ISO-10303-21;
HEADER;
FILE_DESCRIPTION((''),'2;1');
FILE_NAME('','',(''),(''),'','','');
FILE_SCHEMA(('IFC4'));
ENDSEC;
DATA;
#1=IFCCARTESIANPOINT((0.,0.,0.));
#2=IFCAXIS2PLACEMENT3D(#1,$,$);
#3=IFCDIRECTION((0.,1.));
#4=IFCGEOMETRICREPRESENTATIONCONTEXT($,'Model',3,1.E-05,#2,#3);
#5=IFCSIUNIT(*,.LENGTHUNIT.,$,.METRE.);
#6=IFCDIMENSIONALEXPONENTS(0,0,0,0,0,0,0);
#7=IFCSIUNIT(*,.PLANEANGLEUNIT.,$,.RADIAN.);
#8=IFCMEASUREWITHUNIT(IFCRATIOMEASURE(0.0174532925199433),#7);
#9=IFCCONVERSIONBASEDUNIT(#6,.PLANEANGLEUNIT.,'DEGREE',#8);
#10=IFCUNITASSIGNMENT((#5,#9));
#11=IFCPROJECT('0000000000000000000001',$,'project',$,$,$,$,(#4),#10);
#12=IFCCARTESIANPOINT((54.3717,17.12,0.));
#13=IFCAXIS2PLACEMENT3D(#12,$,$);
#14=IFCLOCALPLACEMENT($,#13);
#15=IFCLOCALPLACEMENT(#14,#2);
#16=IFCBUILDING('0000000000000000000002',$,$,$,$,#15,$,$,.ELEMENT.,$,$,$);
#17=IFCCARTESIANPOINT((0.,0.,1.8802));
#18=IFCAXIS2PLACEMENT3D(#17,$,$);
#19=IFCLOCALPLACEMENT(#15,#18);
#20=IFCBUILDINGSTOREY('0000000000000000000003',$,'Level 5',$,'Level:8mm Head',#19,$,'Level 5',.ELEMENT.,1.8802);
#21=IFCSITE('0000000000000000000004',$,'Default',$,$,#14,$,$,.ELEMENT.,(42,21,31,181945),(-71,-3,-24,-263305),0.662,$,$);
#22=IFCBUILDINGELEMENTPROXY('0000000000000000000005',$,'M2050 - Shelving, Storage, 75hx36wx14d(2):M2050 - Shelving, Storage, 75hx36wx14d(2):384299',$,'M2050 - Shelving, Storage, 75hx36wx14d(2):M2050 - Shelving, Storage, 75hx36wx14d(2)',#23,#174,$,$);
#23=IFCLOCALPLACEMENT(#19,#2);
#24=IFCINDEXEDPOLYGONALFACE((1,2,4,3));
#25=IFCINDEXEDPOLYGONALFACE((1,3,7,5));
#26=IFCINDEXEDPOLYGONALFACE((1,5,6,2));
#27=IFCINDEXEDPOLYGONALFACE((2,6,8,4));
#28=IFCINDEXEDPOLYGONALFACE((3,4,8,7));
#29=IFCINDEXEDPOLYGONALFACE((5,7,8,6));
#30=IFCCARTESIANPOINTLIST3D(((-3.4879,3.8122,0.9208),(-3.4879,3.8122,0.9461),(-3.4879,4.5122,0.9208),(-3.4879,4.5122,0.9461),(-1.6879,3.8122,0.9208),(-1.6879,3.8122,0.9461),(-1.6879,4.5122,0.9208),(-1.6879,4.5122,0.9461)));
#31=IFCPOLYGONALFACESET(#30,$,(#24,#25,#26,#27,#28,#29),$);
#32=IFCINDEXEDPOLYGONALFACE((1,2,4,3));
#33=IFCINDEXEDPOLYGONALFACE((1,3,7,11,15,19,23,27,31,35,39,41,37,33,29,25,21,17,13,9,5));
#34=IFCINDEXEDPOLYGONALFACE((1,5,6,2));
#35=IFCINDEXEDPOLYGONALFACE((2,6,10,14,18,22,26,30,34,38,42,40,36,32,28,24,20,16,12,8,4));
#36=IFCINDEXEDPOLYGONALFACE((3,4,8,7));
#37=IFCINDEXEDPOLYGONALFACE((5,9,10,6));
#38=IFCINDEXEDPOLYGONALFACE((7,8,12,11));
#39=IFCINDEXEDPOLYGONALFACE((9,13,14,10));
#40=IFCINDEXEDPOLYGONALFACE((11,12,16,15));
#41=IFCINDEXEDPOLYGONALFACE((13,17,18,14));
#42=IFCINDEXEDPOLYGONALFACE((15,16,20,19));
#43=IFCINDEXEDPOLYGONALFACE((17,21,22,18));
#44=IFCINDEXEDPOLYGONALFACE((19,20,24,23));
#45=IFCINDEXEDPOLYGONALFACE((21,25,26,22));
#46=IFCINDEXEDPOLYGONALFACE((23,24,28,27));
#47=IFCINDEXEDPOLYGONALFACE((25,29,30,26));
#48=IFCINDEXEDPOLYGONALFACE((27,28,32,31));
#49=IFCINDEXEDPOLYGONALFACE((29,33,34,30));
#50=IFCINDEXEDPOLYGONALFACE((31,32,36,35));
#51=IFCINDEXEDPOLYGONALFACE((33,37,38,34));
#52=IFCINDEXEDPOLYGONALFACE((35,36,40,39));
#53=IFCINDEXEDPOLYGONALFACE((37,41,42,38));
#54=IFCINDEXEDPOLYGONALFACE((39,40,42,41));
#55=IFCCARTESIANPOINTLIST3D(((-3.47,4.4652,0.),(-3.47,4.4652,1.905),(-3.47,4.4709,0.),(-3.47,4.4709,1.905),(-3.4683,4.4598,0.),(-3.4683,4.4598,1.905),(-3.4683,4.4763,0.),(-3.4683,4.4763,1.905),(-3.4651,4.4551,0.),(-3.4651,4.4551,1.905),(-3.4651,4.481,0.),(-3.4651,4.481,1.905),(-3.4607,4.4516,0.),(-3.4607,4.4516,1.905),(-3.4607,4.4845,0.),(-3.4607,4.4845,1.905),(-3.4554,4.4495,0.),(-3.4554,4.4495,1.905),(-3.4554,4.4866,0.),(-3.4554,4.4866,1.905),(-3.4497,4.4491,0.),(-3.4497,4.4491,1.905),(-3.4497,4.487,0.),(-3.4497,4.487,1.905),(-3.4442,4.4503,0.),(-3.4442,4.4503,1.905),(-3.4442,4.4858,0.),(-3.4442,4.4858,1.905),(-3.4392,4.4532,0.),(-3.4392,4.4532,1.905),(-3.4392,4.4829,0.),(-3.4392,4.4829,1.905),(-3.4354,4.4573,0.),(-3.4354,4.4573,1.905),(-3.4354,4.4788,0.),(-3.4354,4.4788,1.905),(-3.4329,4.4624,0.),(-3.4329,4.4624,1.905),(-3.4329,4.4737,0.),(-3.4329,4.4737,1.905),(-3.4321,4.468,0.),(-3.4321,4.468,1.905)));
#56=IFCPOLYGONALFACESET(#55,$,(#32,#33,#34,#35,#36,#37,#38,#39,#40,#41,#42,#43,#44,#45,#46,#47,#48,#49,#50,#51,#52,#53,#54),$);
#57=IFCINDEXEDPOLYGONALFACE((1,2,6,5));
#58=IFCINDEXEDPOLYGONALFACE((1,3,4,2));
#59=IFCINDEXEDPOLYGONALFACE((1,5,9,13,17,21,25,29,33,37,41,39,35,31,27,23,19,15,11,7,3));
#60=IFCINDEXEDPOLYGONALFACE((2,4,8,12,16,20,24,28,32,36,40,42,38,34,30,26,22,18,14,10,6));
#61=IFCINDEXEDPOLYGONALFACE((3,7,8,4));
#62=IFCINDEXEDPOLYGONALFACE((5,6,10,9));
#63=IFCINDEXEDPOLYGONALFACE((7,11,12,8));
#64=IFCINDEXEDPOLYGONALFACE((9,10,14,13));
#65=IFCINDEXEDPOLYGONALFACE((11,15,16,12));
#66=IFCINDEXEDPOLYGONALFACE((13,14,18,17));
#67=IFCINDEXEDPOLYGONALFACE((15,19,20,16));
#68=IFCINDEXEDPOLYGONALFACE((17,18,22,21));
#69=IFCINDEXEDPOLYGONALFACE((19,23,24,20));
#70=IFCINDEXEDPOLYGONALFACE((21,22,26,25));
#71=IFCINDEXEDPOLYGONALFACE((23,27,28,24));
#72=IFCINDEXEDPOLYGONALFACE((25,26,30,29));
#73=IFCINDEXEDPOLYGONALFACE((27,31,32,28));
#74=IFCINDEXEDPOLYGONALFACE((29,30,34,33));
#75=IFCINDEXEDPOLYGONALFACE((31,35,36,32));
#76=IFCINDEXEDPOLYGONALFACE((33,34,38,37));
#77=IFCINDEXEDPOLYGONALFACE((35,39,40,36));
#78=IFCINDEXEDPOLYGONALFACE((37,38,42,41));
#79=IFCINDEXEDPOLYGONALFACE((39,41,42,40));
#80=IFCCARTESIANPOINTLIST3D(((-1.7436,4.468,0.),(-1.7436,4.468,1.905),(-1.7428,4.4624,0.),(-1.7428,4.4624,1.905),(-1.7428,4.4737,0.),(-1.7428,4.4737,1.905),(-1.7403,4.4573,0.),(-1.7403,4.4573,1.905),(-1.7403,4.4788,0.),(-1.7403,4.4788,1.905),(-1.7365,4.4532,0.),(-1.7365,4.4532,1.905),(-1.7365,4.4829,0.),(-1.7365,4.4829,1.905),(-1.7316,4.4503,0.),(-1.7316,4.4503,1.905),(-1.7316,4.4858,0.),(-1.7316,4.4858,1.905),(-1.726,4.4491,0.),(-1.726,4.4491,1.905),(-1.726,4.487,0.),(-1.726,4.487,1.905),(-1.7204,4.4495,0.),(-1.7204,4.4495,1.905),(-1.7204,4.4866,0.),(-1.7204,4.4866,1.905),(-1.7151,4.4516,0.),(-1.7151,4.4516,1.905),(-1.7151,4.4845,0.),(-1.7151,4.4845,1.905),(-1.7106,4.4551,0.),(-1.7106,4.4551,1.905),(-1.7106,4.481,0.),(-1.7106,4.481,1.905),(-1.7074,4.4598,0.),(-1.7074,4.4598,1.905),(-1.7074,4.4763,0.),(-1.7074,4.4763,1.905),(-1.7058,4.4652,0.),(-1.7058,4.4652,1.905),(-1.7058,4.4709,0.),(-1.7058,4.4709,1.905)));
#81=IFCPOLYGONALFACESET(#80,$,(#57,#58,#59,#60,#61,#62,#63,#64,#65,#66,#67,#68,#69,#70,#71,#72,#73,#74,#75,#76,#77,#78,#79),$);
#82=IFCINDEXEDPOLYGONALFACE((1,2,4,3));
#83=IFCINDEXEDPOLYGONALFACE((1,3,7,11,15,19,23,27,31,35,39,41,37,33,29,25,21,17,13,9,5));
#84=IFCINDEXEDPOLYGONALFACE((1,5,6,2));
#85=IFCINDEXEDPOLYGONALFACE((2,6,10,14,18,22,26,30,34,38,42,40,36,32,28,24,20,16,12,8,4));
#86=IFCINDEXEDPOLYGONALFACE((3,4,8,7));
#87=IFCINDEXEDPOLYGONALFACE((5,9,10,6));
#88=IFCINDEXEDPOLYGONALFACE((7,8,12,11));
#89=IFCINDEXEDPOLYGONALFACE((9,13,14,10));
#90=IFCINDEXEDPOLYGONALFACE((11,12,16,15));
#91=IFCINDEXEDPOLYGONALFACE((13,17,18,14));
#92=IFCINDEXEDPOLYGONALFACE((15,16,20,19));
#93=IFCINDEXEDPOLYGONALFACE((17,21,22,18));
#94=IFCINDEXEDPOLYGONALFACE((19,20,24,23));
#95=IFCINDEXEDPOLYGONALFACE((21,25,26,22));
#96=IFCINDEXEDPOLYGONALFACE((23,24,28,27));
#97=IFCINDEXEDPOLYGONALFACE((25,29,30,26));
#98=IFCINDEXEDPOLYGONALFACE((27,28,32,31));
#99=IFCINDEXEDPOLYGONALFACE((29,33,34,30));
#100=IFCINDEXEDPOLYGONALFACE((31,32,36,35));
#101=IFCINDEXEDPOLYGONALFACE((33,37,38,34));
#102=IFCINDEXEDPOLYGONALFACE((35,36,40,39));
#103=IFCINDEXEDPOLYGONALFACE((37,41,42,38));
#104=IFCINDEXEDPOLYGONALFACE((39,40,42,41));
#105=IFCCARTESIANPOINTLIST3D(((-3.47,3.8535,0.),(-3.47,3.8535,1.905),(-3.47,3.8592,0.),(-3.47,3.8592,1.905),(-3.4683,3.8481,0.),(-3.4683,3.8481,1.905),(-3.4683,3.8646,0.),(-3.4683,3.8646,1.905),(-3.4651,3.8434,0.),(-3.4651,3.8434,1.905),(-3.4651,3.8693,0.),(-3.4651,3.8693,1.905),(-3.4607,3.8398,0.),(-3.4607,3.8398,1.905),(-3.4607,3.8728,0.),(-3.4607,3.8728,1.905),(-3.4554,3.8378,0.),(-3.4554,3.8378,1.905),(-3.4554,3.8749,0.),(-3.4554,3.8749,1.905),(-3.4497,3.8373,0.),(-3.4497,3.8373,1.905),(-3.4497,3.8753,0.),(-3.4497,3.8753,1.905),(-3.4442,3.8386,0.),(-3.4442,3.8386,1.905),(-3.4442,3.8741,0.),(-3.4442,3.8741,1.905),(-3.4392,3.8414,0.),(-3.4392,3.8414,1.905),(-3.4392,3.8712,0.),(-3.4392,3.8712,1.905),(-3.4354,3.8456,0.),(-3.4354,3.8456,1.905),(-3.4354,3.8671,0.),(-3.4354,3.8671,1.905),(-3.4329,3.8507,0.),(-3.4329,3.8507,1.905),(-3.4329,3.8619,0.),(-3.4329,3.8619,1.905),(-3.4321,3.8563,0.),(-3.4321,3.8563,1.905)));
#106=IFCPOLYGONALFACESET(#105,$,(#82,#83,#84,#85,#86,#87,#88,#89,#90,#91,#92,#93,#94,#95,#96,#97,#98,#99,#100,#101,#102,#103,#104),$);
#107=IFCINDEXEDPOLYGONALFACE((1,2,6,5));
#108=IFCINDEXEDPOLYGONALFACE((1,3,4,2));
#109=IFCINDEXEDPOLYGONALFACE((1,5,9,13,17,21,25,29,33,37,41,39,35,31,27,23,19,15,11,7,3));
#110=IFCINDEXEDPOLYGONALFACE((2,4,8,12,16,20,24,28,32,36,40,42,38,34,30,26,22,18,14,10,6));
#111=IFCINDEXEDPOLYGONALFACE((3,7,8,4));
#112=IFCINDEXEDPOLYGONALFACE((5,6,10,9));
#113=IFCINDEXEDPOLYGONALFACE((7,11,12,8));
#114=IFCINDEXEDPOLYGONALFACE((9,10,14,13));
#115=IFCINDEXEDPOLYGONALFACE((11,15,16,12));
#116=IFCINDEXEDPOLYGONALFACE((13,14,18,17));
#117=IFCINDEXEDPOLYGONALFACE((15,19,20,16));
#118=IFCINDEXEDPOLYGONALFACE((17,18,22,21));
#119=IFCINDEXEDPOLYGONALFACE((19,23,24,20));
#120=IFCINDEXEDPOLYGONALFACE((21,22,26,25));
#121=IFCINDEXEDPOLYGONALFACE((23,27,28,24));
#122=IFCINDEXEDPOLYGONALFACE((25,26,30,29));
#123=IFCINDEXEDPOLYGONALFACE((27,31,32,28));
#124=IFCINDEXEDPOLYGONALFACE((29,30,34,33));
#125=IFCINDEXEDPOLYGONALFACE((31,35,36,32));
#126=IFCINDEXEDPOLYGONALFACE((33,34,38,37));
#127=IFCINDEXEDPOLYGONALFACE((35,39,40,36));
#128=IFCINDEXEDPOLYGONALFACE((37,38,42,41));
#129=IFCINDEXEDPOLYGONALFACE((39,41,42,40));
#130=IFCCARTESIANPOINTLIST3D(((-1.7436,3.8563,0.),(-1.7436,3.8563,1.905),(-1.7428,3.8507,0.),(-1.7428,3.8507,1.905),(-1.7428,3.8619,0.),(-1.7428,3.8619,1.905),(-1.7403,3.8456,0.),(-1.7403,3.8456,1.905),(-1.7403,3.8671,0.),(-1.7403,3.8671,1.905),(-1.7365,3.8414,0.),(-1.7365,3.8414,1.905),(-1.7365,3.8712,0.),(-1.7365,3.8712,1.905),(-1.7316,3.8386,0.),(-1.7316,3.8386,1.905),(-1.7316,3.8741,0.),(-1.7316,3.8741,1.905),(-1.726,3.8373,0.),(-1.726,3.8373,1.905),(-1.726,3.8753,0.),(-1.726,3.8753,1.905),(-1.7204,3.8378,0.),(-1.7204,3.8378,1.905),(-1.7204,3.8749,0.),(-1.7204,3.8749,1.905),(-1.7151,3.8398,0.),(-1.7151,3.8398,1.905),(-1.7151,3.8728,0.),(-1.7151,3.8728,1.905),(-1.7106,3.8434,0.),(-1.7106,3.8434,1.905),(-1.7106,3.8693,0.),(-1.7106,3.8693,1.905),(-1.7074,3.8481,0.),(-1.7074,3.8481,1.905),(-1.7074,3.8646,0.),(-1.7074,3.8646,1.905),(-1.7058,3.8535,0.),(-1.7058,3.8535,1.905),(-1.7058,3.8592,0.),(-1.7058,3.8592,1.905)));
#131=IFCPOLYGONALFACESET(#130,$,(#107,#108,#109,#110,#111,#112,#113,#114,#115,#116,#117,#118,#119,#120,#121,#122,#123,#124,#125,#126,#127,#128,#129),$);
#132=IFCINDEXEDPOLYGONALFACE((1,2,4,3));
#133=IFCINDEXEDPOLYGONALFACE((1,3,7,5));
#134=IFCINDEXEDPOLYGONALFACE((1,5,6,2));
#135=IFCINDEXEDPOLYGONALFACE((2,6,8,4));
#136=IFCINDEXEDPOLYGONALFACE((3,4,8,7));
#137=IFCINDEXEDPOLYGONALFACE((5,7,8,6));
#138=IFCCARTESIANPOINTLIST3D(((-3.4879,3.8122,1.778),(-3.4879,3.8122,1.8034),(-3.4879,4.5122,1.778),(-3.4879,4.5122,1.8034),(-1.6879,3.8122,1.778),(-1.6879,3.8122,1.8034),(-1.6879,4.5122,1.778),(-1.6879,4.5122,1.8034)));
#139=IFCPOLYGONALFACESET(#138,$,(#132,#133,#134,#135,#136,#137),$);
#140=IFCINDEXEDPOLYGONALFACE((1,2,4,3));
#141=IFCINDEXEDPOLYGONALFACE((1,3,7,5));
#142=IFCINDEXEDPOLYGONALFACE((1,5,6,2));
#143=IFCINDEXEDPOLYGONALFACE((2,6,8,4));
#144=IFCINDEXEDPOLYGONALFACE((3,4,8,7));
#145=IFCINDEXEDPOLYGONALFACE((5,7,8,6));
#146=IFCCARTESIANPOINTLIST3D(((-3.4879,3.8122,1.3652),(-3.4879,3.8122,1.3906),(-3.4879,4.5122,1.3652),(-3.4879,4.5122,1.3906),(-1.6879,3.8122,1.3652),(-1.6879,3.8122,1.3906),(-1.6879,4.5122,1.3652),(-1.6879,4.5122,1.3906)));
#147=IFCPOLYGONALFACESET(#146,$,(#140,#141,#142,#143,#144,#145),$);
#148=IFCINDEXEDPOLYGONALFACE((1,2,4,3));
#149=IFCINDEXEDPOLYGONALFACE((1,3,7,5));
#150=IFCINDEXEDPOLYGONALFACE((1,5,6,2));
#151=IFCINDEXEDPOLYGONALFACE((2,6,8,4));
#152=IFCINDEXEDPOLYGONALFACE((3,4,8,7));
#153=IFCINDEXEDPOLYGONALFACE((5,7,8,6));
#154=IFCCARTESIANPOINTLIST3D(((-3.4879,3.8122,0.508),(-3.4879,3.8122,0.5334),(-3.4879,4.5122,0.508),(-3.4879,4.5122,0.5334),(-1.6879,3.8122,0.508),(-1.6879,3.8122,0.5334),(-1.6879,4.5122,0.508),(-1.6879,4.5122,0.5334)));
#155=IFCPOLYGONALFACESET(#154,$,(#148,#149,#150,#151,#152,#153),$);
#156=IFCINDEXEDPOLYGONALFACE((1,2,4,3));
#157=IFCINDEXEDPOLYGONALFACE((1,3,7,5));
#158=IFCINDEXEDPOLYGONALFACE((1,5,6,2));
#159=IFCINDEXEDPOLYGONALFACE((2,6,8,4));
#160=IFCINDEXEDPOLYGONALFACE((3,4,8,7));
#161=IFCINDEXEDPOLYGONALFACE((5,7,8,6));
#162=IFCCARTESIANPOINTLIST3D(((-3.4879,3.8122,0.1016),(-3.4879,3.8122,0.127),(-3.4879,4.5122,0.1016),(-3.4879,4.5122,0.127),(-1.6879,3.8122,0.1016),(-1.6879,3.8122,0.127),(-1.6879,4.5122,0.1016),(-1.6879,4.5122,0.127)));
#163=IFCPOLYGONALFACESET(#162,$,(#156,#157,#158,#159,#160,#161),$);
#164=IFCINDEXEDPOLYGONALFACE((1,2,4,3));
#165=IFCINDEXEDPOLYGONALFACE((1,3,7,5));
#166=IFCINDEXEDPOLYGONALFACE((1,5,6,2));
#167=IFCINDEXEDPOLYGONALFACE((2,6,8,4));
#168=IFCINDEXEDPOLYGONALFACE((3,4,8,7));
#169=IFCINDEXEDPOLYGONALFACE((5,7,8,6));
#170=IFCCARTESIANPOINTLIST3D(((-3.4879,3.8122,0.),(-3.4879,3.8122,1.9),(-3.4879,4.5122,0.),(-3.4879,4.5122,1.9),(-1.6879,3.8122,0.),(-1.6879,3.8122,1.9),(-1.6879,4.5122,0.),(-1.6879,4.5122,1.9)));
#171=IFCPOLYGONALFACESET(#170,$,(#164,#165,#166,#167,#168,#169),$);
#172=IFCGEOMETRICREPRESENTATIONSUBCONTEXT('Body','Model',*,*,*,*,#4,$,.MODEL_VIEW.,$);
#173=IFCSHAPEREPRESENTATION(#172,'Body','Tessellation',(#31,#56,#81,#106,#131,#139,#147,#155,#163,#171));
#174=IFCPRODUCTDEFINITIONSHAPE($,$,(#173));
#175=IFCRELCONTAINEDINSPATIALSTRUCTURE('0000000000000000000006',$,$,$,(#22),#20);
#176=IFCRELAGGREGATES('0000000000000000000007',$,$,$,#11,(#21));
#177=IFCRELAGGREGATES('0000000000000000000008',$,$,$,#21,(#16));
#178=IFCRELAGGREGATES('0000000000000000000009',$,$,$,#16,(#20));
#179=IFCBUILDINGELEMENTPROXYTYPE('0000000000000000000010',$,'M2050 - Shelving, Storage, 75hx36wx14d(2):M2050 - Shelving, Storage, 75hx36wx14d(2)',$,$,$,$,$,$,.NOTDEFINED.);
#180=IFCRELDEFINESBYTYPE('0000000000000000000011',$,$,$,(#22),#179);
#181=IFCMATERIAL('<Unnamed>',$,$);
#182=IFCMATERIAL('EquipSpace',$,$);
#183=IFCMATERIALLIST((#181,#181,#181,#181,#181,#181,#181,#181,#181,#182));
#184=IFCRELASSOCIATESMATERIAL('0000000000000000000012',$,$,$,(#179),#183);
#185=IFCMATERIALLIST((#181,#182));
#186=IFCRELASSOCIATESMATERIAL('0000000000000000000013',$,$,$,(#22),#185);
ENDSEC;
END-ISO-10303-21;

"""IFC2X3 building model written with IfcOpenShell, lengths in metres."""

from ifc_helpers import new_model, entity, si_unit, converted_unit, direction, frame, frame_2d, origin, origin_2d_with_axis, place, context, subcontext, project, spatial, rectangle, circle, extrude, source, transform, mapped, material, material_list, type_object, type_shapes, element, save


model = new_model("IFC2X3")

# Units and contexts
model_context = context("Model", 3, precision=1e-05, world=origin(), true_north=direction((0.0, 1.0)))
body_context = subcontext(model_context, "Body", "Model", "MODEL_VIEW")
ifc_project = project(units=[si_unit("LENGTHUNIT", "METRE"), converted_unit("PLANEANGLEUNIT", "DEGREE", entity("IfcRatioMeasure", 0.0174532925199433), si_unit("PLANEANGLEUNIT", "RADIAN"), dimensions=[0, 0, 0, 0, 0, 0, 0])], contexts=[model_context])

# Site, building, storey
site_placement = place(None, frame((54.3717, 17.12, 0.0)))
site = spatial("IfcSite", under=ifc_project, at=site_placement, Name="Default", CompositionType="ELEMENT", RefLatitude=(42, 21, 31, 181945), RefLongitude=(-71, -3, -24, -263305), RefElevation=0.662)
building_placement = place(site_placement, origin())
building = spatial("IfcBuilding", under=site, at=building_placement, CompositionType="ELEMENT")
storey_placement = place(building_placement, frame((0.0, 0.0, 1.8802)))
storey = spatial("IfcBuildingStorey", under=building, at=storey_placement, Name="Level 5", ObjectType="Level:8mm Head", LongName="Level 5", CompositionType="ELEMENT", Elevation=1.8802)

# Building element proxy
ifc_material_1 = material(Name="<Unnamed>")
ifc_material_2 = material(Name="EquipSpace")
ifc_material_list_1 = material_list([ifc_material_1, ifc_material_1, ifc_material_1, ifc_material_1, ifc_material_1, ifc_material_1, ifc_material_1, ifc_material_1, ifc_material_1, ifc_material_2])
building_element_proxy_type = type_object("IfcBuildingElementProxyType", Name="M2050 - Shelving, Storage, 75hx36wx14d(2):M2050 - Shelving, Storage, 75hx36wx14d(2)", PredefinedType="NOTDEFINED", material=ifc_material_list_1)
shared_shape = source(origin(), body_context, "Body", "SweptSolid", [
    extrude(rectangle(XDim=1.8, YDim=0.7, at=origin_2d_with_axis()), frame((0.0, 0.0, 0.9207), z_axis=(0.0, 0.0, 1.0), x_axis=(-1.0, 0.0, 0.0)), (0.0, 0.0, 1.0), 0.0254),
    extrude(circle(Radius=0.0191, at=origin_2d_with_axis()), frame((0.8633, -0.3059, 0.0), z_axis=(0.0, 0.0, 1.0), x_axis=(-1.0, 0.0, 0.0)), (0.0, 0.0, 1.0), 1.905),
    extrude(circle(Radius=0.0191, at=origin_2d_with_axis()), frame((-0.8633, -0.3059, 0.0)), (0.0, 0.0, 1.0), 1.905),
    extrude(circle(Radius=0.0191, at=origin_2d_with_axis()), frame((0.8633, 0.3059, 0.0), z_axis=(0.0, 0.0, 1.0), x_axis=(-1.0, 0.0, 0.0)), (0.0, 0.0, 1.0), 1.905),
    extrude(circle(Radius=0.0191, at=origin_2d_with_axis()), frame((-0.8633, 0.3059, 0.0)), (0.0, 0.0, 1.0), 1.905),
    extrude(rectangle(XDim=1.8, YDim=0.7, at=origin_2d_with_axis()), frame((0.0, 0.0, 1.778), z_axis=(0.0, 0.0, 1.0), x_axis=(-1.0, 0.0, 0.0)), (0.0, 0.0, 1.0), 0.0254),
    extrude(rectangle(XDim=1.8, YDim=0.7, at=origin_2d_with_axis()), frame((0.0, 0.0, 1.3653), z_axis=(0.0, 0.0, 1.0), x_axis=(-1.0, 0.0, 0.0)), (0.0, 0.0, 1.0), 0.0254),
    extrude(rectangle(XDim=1.8, YDim=0.7, at=origin_2d_with_axis()), frame((0.0, 0.0, 0.508), z_axis=(0.0, 0.0, 1.0), x_axis=(-1.0, 0.0, 0.0)), (0.0, 0.0, 1.0), 0.0254),
    extrude(rectangle(XDim=1.8, YDim=0.7, at=origin_2d_with_axis()), frame((0.0, 0.0, 0.1016), z_axis=(0.0, 0.0, 1.0), x_axis=(-1.0, 0.0, 0.0)), (0.0, 0.0, 1.0), 0.0254),
    extrude(rectangle(XDim=0.7, YDim=1.8, at=frame_2d((0.0, 0.18), x_axis=(1.0, 0.0))), frame((-0.18, 0.0, 0.0), z_axis=(0.0, 0.0, 1.0), x_axis=(0.0, -1.0, 0.0)), (0.0, 0.0, 1.0), 1.9),
])
type_shapes(building_element_proxy_type, [shared_shape])
ifc_material_list_2 = material_list([ifc_material_1, ifc_material_2])
proxy_1_placement = place(storey_placement, frame((-2.5879, 4.1622, 0.0), z_axis=(0.0, 0.0, 1.0), x_axis=(-1.0, 0.0, 0.0)))
element("IfcBuildingElementProxy", 1, at=proxy_1_placement, inside=storey, type_object=building_element_proxy_type, material=ifc_material_list_2, Name="M2050 - Shelving, Storage, 75hx36wx14d(2):M2050 - Shelving, Storage, 75hx36wx14d(2):384299", ObjectType="M2050 - Shelving, Storage, 75hx36wx14d(2):M2050 - Shelving, Storage, 75hx36wx14d(2)", context=body_context, shape_type="MappedRepresentation", body=[
    mapped(shared_shape, transform((0.0, 0.0, 0.0), scale=1.0)),
])

save(model, "model.ifc")
